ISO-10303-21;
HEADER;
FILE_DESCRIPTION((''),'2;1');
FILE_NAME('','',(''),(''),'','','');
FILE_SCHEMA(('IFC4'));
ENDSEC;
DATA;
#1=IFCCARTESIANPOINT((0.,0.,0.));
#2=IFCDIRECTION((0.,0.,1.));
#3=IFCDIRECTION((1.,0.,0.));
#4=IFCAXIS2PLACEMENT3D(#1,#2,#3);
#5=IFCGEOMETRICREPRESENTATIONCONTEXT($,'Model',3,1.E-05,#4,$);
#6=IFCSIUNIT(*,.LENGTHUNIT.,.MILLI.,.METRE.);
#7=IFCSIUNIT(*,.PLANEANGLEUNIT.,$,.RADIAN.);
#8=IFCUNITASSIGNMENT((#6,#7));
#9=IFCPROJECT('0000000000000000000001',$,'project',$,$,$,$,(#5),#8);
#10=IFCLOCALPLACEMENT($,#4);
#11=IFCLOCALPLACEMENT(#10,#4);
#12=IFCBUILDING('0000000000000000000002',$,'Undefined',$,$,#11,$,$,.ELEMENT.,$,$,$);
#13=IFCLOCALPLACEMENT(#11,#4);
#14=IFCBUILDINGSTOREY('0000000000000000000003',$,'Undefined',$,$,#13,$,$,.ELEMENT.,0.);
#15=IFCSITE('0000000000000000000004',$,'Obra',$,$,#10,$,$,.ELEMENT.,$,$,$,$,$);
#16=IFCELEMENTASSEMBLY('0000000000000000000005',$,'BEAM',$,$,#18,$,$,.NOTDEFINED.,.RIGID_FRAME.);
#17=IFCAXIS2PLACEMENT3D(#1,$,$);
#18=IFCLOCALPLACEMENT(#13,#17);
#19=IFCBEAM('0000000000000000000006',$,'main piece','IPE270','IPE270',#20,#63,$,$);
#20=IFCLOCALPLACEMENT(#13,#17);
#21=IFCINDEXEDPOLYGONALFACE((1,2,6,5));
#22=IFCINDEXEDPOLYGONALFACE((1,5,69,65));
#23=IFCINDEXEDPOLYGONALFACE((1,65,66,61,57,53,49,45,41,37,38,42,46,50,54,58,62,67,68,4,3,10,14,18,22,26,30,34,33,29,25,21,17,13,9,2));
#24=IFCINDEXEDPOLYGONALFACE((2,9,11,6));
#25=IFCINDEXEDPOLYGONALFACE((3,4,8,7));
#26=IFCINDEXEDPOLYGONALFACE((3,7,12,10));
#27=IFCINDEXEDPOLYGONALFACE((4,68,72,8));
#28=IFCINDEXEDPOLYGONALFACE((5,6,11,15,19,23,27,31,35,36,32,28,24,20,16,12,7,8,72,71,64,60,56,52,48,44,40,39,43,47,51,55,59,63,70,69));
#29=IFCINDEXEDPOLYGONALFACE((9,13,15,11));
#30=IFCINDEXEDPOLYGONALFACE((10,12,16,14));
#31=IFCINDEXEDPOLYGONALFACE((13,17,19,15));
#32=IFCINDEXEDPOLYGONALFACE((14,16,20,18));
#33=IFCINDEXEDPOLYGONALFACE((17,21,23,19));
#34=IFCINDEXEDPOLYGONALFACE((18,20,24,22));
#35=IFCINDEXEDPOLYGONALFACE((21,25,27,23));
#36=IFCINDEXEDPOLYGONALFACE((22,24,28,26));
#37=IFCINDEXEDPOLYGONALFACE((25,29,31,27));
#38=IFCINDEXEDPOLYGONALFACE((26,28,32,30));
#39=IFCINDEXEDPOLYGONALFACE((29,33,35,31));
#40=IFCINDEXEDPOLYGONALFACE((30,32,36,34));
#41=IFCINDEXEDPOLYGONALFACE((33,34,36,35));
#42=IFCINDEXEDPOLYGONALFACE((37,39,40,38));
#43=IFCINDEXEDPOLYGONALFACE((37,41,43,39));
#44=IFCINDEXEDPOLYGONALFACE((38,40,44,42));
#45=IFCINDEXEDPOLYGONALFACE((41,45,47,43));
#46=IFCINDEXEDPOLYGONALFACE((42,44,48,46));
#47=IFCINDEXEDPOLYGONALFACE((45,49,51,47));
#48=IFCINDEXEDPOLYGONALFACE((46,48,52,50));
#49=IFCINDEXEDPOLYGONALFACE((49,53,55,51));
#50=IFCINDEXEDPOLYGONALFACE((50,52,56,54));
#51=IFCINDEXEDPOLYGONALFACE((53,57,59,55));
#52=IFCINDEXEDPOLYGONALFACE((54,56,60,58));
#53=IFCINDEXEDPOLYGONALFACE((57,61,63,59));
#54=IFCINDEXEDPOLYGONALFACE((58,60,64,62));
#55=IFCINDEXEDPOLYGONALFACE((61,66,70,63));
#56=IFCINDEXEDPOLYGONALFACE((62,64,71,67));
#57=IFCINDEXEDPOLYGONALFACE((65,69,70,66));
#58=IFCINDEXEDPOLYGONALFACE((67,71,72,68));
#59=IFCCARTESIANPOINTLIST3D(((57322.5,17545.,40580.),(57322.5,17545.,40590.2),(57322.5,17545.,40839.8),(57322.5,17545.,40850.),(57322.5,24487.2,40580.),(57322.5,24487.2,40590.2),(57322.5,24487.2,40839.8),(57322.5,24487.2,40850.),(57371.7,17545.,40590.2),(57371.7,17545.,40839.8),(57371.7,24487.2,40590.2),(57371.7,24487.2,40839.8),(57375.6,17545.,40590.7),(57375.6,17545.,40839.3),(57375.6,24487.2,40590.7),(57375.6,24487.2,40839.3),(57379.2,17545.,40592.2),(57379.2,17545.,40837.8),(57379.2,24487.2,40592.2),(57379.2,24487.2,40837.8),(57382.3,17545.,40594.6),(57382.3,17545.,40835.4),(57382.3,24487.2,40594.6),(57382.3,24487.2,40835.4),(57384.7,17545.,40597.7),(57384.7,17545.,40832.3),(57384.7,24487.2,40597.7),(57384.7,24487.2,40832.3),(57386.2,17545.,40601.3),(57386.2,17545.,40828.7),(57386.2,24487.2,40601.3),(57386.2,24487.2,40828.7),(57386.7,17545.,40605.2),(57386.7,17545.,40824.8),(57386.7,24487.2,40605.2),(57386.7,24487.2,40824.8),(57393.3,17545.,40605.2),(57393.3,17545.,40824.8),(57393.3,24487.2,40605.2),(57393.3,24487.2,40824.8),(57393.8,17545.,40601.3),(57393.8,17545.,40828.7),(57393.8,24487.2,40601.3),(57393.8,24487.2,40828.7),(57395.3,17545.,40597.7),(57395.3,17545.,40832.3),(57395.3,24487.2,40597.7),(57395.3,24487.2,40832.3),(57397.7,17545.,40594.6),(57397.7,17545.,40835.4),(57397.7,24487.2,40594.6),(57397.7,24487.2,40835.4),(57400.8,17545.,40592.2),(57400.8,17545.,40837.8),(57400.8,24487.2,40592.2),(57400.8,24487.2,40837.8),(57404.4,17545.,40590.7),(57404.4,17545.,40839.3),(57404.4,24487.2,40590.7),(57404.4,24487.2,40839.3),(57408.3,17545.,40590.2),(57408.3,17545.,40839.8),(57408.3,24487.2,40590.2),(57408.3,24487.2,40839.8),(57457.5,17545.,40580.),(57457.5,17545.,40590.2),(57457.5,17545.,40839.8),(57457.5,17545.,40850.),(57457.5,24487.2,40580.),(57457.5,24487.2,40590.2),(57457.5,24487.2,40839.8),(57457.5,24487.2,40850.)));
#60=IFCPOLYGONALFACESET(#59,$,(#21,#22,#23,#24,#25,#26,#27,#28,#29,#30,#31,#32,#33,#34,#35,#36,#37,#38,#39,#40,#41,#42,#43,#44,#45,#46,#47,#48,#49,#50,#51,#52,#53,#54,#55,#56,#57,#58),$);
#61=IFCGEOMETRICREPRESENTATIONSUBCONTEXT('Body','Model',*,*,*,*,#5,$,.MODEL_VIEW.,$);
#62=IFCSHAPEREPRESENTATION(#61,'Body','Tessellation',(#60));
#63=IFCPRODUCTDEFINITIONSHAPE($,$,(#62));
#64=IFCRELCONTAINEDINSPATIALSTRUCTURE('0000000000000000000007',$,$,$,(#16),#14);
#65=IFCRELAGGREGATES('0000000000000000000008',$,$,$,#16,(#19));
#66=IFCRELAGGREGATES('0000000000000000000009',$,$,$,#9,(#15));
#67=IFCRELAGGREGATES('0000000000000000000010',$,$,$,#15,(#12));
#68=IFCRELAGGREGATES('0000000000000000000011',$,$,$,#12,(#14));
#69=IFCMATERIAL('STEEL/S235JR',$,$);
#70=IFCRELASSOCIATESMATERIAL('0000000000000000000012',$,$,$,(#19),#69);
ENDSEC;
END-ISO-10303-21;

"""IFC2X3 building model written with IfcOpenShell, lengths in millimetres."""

from ifc_helpers import new_model, si_unit, frame, origin_with_axes, origin_2d_with_axis, place, context, subcontext, project, spatial, i_section, extrude, material, element, aggregate, save


model = new_model("IFC2X3")

# Units and contexts
model_context = context("Model", 3, precision=1e-05, world=origin_with_axes())
body_context = subcontext(model_context, "Body", "Model", "MODEL_VIEW")
ifc_project = project(units=[si_unit("LENGTHUNIT", "METRE", prefix="MILLI"), si_unit("PLANEANGLEUNIT", "RADIAN")], contexts=[model_context])

# Site, building, storey
site_placement = place(None, origin_with_axes())
site = spatial("IfcSite", under=ifc_project, at=site_placement, Name="Obra", CompositionType="ELEMENT")
building_placement = place(site_placement, origin_with_axes())
building = spatial("IfcBuilding", under=site, at=building_placement, Name="Undefined", CompositionType="ELEMENT")
storey_placement = place(building_placement, origin_with_axes())
storey = spatial("IfcBuildingStorey", under=building, at=storey_placement, Name="Undefined", CompositionType="ELEMENT", Elevation=0.0)

# Shared definitions
ifc_material_1 = material(Name="STEEL/S235JR")

# Element assembly, beam
assembly_1_placement = place(storey_placement, origin_with_axes())
assembly_1 = element("IfcElementAssembly", 1, at=assembly_1_placement, inside=storey, Name="BEAM", AssemblyPlace="NOTDEFINED", PredefinedType="RIGID_FRAME")
beam_1_placement = place(assembly_1_placement, frame((57390.0, 17545.0, 40715.0), z_axis=(0.0, 0.0, 1.0), x_axis=(0.0, 1.0, 0.0)))
beam_1 = element("IfcBeam", 2, at=beam_1_placement, material=ifc_material_1, Name="main piece", Description="IPE270", ObjectType="IPE270", context=body_context, shape_type="SweptSolid", body=[
    extrude(i_section(OverallWidth=135.0, OverallDepth=270.0, WebThickness=6.6, FlangeThickness=10.2, FilletRadius=15.0, at=origin_2d_with_axis()), frame((6942.2, 0.0, 0.0), z_axis=(-1.0, 0.0, 0.0), x_axis=(0.0, -1.0, 0.0)), (0.0, 0.0, 1.0), 6942.2),
])
aggregate(assembly_1, [beam_1])

save(model, "model.ifc")
